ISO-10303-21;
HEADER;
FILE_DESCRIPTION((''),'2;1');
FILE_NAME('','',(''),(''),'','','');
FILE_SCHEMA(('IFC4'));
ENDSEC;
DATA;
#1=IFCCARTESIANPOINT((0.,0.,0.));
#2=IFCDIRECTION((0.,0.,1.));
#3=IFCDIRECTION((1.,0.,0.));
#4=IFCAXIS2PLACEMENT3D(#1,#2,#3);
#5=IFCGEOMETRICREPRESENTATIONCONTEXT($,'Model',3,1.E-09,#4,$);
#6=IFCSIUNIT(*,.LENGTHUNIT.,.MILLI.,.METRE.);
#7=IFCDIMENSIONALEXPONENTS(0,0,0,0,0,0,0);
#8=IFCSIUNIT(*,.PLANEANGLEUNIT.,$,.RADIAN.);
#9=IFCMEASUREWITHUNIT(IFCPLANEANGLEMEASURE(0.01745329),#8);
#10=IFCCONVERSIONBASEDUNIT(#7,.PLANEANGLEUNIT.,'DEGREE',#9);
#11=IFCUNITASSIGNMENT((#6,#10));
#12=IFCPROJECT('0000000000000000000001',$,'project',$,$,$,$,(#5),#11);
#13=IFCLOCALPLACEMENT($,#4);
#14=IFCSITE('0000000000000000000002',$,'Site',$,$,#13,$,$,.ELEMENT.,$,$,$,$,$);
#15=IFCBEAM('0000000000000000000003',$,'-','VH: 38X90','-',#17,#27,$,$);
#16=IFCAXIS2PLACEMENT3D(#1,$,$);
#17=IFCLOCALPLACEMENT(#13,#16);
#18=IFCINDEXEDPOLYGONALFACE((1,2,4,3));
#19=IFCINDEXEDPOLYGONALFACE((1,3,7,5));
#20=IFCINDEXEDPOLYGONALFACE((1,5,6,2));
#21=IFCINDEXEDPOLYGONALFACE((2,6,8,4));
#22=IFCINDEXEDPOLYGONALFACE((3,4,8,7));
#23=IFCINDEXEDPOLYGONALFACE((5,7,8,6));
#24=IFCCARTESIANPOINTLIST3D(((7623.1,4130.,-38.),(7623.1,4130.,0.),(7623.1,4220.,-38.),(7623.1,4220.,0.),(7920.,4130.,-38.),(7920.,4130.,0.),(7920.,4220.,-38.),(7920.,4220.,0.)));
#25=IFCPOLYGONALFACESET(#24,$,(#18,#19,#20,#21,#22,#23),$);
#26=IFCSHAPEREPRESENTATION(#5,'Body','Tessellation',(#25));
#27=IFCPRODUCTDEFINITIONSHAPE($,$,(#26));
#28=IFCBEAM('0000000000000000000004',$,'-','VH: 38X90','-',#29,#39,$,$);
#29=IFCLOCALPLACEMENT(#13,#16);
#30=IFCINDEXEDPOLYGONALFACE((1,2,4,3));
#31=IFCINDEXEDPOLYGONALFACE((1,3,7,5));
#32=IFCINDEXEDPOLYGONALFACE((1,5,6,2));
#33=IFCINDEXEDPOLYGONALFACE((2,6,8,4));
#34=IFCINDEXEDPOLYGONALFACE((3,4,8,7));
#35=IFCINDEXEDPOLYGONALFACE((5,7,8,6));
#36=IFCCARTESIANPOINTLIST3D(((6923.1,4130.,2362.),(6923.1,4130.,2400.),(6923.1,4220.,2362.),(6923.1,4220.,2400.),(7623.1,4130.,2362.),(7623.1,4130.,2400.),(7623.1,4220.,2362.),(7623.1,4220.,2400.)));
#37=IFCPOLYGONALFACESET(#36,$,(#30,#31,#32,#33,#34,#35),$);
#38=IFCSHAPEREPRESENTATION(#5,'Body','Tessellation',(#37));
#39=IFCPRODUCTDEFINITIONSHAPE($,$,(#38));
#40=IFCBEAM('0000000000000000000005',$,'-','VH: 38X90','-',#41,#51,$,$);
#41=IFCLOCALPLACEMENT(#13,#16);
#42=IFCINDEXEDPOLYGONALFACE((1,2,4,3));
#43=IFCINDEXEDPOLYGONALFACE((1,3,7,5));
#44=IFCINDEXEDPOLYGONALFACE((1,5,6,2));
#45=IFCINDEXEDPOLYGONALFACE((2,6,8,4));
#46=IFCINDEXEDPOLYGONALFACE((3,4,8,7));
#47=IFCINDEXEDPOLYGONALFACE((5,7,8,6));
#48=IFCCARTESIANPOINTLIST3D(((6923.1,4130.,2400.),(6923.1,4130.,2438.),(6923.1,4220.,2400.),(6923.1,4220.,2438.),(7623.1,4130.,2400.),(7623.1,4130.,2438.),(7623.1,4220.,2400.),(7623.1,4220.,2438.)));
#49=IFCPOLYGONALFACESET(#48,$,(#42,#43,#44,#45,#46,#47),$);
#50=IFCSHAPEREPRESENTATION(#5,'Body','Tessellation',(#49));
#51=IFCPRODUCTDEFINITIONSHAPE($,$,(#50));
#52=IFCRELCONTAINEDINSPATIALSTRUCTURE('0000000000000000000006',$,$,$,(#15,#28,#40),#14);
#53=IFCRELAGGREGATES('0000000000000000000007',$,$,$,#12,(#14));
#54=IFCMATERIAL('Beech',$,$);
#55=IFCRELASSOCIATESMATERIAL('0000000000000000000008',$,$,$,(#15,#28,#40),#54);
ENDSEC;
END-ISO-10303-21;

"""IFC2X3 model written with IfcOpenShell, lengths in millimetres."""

from ifc_helpers import new_model, entity, si_unit, converted_unit, frame, origin, origin_with_axes, origin_2d, place, context, project, spatial, rectangle, extrude, material, element, save


model = new_model("IFC2X3")

# Units and contexts
model_context = context("Model", 3, precision=1e-09, world=origin_with_axes())
ifc_project = project(units=[si_unit("LENGTHUNIT", "METRE", prefix="MILLI"), converted_unit("PLANEANGLEUNIT", "DEGREE", entity("IfcPlaneAngleMeasure", 0.01745329), si_unit("PLANEANGLEUNIT", "RADIAN"), dimensions=[0, 0, 0, 0, 0, 0, 0])], contexts=[model_context])

# Site
site_placement = place(None, origin_with_axes())
site = spatial("IfcSite", under=ifc_project, at=site_placement, Name="Site", CompositionType="ELEMENT")

# Shared definitions
ifc_material = material(Name="Beech")

# Beams
beam_1_placement = place(None, frame((7920.0, 4175.0, -19.0), z_axis=(1.0, 0.0, 0.0), x_axis=(0.0, 0.0, 1.0)))
element("IfcBeam", 1, at=beam_1_placement, inside=site, material=ifc_material, Name="-", Description="VH: 38X90", ObjectType="-", context=model_context, shape_type="SweptSolid", body=[
    extrude(rectangle(XDim=38.0, YDim=90.0, at=origin_2d()), origin(), (0.0, 0.0, -1.0), 296.9),
])
beam_2_placement = place(None, frame((6923.1, 4175.0, 2381.0), z_axis=(-1.0, 0.0, 0.0), x_axis=(0.0, 0.0, -1.0)))
element("IfcBeam", 2, at=beam_2_placement, inside=site, material=ifc_material, Name="-", Description="VH: 38X90", ObjectType="-", context=model_context, shape_type="SweptSolid", body=[
    extrude(rectangle(XDim=38.0, YDim=90.0, at=origin_2d()), origin(), (0.0, 0.0, -1.0), 700.0),
])
beam_3_placement = place(None, frame((6923.1, 4175.0, 2419.0), z_axis=(-1.0, -0.000037, 0.0), x_axis=(0.0, 0.0, -1.0)))
element("IfcBeam", 3, at=beam_3_placement, inside=site, material=ifc_material, Name="-", Description="VH: 38X90", ObjectType="-", context=model_context, shape_type="SweptSolid", body=[
    extrude(rectangle(XDim=38.0, YDim=90.0, at=origin_2d()), origin(), (0.0, 0.0, -1.0), 700.0),
])

save(model, "model.ifc")
